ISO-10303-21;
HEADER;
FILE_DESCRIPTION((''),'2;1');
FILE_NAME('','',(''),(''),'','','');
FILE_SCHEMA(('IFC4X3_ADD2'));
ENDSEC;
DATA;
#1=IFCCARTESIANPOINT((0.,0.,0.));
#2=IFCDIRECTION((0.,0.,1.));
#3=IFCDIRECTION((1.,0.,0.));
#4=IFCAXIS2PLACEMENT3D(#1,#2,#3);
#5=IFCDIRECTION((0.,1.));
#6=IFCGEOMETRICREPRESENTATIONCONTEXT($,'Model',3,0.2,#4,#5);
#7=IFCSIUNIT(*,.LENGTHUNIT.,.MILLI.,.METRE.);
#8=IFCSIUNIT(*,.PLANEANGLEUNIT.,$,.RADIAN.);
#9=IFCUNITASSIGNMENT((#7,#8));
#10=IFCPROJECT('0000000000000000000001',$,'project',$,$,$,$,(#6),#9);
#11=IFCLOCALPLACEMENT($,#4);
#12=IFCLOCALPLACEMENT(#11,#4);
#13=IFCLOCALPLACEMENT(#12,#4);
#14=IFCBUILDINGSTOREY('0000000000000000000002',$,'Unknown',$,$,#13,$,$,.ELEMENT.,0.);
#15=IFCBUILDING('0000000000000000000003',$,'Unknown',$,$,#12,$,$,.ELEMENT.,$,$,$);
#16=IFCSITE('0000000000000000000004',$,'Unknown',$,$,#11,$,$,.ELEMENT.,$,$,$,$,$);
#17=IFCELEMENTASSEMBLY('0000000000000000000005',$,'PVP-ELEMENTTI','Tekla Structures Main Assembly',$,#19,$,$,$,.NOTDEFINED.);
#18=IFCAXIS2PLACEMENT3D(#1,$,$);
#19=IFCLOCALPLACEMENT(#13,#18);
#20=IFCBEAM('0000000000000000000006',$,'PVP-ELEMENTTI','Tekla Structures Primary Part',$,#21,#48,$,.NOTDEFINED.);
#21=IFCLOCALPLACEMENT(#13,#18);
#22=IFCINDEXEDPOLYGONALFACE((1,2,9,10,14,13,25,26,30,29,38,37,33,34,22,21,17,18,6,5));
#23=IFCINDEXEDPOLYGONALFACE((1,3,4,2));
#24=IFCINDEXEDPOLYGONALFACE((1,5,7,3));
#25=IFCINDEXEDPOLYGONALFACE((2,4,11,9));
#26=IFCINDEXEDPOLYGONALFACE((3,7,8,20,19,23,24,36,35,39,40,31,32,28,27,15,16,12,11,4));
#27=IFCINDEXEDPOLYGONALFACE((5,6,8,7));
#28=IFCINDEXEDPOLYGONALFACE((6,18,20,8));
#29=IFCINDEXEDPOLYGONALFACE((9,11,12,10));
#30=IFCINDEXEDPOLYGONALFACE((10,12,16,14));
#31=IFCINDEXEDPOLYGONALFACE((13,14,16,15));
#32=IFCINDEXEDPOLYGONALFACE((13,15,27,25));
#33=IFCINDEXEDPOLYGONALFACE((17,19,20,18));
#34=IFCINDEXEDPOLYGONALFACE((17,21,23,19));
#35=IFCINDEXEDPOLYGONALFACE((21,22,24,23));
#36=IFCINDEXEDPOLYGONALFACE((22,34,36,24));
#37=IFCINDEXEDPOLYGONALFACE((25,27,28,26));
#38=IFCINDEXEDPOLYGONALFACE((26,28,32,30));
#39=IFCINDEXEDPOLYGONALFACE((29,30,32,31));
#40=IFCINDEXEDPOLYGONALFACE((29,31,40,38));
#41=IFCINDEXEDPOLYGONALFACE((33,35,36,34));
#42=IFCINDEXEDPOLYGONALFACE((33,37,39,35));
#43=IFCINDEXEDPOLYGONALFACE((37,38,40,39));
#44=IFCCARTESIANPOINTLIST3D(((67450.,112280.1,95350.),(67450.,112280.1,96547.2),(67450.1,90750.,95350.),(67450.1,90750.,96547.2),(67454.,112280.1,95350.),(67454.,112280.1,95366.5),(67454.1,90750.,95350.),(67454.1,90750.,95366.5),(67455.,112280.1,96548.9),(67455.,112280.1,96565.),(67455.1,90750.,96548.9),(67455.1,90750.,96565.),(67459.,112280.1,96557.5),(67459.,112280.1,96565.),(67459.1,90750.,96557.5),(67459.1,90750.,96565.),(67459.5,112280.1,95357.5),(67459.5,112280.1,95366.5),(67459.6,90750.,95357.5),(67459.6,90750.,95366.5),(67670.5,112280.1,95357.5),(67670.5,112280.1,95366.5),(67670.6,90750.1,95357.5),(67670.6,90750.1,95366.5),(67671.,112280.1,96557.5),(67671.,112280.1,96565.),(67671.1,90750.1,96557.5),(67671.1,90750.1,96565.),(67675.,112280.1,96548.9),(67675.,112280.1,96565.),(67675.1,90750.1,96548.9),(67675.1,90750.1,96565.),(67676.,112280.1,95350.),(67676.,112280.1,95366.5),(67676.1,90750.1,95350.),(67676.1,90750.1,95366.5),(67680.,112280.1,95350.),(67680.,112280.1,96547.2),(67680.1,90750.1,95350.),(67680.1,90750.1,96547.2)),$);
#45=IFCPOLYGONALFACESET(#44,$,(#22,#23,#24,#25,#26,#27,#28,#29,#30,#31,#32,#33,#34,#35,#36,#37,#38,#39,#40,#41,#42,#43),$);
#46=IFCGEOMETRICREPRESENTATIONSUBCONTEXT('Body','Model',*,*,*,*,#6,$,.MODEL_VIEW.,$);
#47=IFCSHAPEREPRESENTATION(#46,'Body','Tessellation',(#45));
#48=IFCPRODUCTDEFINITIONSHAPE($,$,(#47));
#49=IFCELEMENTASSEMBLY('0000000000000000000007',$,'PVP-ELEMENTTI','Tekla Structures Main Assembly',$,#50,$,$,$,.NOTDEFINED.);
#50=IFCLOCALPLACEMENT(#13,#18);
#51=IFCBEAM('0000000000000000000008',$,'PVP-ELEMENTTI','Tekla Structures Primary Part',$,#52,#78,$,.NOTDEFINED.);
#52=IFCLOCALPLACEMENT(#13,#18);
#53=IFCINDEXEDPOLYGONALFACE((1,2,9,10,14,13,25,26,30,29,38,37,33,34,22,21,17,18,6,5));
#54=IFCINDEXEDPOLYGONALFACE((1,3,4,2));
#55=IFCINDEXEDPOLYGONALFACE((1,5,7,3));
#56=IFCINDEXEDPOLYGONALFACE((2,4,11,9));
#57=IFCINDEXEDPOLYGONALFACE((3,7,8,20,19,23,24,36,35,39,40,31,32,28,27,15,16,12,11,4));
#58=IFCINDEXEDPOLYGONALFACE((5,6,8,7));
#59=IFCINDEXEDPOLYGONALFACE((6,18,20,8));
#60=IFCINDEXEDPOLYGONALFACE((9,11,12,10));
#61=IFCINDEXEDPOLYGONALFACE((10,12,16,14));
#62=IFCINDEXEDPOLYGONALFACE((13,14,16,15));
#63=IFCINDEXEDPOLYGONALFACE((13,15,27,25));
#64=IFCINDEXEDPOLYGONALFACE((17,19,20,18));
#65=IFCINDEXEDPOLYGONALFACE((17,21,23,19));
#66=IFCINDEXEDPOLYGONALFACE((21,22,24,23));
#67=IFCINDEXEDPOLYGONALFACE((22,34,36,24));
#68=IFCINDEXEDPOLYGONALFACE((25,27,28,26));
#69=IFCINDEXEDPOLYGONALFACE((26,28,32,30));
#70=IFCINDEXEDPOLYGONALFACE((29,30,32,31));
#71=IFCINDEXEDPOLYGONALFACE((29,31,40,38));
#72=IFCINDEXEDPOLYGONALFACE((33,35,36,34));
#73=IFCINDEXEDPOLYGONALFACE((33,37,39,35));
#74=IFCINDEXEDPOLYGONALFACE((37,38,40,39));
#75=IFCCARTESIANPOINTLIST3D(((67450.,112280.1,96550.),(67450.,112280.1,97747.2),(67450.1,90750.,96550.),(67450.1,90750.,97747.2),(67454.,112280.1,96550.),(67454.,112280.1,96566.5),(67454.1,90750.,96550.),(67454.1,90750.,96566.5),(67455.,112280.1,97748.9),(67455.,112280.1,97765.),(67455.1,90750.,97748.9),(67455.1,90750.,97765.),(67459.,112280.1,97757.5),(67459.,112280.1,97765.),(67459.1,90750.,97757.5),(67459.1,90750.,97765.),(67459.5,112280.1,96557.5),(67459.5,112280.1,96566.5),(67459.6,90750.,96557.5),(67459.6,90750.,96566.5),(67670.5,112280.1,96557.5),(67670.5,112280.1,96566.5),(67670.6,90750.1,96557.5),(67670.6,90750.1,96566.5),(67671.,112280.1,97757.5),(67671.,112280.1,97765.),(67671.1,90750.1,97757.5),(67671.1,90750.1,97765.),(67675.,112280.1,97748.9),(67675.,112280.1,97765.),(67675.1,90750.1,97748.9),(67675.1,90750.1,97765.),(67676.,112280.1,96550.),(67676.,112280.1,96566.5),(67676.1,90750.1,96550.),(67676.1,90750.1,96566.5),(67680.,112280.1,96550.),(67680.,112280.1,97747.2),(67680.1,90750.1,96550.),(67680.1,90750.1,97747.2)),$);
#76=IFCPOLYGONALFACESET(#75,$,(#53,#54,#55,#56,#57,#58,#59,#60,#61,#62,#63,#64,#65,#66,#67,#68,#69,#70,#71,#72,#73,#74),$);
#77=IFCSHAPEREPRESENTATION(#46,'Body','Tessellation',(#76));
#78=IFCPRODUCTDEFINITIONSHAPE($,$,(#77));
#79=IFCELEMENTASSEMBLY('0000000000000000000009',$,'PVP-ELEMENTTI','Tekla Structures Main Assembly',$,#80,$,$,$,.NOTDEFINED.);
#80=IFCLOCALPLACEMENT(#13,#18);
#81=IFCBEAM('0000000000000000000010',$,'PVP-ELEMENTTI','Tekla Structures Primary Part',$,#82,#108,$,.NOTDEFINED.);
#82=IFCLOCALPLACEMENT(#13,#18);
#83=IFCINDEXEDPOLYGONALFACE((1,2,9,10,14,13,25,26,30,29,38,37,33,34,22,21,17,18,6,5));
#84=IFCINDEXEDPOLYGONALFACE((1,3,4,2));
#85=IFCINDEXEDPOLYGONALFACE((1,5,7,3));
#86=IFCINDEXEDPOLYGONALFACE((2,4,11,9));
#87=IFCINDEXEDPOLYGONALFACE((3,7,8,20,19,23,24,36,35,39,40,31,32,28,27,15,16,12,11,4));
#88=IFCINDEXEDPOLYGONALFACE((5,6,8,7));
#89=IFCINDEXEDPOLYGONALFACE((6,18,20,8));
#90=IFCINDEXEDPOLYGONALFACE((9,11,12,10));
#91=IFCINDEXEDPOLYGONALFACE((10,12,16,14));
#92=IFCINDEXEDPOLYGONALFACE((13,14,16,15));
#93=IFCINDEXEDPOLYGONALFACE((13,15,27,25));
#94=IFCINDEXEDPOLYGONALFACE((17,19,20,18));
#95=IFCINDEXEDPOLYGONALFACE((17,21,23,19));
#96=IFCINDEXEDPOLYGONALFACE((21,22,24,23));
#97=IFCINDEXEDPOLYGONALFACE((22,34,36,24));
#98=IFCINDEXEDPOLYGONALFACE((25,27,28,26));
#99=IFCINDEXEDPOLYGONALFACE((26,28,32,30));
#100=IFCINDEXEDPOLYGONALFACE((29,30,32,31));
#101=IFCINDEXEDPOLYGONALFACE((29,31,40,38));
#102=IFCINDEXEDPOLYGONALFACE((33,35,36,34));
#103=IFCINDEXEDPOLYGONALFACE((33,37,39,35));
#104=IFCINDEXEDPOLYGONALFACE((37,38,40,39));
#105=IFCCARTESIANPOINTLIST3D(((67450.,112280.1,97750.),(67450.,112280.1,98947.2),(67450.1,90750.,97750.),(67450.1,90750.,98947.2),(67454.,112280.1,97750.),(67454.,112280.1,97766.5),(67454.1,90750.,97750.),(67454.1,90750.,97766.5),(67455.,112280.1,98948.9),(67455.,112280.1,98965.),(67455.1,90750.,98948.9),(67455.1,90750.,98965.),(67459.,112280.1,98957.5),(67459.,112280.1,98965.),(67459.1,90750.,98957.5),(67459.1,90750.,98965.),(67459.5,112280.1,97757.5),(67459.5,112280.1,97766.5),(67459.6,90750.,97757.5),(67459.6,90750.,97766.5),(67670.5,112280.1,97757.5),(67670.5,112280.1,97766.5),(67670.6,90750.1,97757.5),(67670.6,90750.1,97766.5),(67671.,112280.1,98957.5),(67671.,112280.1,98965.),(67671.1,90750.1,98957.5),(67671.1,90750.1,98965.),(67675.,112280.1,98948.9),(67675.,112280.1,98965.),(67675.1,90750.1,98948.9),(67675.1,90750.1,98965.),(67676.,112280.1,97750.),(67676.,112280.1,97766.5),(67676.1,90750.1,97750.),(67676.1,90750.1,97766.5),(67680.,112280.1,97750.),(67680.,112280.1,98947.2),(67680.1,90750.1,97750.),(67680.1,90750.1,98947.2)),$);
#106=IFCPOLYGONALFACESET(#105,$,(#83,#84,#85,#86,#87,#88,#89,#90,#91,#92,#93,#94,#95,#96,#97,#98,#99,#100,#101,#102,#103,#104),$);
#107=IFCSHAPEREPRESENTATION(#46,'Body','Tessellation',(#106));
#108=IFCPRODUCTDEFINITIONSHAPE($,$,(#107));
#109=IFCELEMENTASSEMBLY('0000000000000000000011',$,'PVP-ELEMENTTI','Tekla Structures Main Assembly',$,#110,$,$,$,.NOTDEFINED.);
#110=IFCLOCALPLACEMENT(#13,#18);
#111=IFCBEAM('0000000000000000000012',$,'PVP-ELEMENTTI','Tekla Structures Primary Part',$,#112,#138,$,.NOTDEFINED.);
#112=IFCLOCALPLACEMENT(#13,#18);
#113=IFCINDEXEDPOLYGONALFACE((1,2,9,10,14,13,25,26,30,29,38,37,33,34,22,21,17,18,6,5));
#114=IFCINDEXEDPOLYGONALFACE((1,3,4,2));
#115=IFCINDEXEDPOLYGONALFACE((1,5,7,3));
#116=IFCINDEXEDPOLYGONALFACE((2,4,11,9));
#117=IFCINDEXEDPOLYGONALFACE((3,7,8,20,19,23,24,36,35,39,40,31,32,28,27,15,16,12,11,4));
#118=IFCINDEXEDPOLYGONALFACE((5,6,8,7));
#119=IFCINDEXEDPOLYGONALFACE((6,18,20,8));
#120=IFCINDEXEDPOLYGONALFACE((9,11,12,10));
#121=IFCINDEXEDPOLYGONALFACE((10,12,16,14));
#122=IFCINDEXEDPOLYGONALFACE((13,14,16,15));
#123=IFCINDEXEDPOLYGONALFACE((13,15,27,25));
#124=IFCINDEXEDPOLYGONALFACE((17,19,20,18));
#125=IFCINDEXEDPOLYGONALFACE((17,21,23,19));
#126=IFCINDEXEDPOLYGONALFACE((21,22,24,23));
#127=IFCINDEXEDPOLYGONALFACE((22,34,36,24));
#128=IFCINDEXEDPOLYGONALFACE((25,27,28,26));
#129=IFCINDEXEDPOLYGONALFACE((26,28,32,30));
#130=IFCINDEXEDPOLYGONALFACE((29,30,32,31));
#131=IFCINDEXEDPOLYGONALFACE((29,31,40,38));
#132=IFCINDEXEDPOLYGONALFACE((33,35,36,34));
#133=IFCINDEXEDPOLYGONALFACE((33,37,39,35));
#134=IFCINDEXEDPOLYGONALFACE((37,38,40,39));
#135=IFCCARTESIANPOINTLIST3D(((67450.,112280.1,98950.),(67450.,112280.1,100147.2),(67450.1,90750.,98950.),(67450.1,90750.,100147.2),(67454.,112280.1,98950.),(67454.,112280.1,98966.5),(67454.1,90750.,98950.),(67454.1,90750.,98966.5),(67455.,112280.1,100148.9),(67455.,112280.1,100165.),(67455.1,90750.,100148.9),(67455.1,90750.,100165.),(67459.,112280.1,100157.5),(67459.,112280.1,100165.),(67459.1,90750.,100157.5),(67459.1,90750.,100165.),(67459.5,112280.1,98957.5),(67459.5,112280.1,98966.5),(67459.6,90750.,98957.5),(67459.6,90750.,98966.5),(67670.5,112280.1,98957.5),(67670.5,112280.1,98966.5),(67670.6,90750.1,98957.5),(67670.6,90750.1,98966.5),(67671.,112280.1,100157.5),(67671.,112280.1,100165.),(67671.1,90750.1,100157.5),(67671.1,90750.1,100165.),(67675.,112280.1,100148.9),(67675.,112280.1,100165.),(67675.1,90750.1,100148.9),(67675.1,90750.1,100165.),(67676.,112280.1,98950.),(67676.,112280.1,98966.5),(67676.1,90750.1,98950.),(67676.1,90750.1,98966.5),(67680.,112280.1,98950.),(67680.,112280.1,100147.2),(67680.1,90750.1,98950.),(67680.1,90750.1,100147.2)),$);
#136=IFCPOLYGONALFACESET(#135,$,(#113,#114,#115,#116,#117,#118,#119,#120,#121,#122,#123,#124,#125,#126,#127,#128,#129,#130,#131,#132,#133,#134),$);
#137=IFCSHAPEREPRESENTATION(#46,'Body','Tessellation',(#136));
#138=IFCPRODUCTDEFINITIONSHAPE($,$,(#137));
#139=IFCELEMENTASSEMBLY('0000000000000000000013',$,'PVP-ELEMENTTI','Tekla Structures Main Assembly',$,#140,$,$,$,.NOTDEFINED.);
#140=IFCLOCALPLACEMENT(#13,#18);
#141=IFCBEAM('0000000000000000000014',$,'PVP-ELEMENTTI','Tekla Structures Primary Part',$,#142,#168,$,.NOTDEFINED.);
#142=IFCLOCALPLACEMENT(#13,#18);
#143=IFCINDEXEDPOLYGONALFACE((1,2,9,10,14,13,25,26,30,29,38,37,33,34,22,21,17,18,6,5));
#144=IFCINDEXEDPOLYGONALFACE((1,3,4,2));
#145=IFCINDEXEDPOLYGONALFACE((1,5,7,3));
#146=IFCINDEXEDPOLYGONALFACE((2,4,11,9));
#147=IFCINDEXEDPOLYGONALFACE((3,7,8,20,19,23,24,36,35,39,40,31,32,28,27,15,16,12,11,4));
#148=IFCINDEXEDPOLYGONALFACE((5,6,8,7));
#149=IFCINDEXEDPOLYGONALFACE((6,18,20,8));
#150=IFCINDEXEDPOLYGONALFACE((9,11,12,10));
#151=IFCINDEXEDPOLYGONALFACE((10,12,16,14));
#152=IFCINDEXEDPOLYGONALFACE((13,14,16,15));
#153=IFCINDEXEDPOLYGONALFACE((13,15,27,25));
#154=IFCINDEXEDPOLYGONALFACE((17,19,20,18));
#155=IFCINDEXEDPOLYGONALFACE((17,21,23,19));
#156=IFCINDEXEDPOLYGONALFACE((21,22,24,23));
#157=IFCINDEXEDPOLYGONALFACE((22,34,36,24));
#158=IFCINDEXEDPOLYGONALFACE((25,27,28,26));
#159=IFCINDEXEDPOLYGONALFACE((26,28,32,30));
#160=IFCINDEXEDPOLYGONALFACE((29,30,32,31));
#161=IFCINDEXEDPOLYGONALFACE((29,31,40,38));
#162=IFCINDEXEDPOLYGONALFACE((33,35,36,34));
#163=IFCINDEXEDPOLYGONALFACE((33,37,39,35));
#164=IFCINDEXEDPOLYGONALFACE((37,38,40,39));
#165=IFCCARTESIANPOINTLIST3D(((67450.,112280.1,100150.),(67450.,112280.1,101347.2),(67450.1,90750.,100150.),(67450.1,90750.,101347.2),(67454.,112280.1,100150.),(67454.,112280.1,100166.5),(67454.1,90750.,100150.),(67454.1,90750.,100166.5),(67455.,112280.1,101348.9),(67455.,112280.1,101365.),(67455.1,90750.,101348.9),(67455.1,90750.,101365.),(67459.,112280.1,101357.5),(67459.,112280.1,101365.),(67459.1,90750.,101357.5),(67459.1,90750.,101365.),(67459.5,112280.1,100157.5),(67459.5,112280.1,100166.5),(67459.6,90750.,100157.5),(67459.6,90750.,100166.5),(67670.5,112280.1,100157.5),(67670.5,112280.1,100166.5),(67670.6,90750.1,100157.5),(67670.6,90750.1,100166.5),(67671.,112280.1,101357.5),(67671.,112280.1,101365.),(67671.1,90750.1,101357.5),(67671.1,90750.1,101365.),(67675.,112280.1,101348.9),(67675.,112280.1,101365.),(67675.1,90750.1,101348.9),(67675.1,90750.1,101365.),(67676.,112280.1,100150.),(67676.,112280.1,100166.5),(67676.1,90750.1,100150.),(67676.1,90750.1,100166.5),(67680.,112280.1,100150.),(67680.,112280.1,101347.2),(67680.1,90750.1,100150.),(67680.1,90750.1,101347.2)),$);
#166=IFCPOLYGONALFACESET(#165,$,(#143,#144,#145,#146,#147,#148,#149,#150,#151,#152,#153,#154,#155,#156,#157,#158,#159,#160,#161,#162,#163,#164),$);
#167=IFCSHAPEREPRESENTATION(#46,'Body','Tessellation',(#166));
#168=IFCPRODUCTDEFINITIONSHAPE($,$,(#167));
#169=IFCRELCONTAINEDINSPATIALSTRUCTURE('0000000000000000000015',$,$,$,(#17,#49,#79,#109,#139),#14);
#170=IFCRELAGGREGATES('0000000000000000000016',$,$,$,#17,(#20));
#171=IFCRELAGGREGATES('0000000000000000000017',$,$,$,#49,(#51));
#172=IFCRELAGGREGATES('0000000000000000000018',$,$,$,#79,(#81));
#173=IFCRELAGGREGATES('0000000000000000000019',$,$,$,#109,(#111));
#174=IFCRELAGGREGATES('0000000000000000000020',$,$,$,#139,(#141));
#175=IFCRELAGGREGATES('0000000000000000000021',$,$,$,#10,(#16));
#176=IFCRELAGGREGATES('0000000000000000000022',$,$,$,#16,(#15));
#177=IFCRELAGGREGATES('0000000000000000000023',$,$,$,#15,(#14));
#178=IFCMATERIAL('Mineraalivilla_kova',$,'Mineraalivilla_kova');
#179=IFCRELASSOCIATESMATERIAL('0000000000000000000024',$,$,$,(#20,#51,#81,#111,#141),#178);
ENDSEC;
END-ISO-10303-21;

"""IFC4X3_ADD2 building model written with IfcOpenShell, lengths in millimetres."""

from ifc_helpers import new_model, si_unit, direction, frame, origin_with_axes, place, context, subcontext, project, spatial, line, indexed_curve, outline, extrude, material, element, aggregate, save


model = new_model("IFC4X3_ADD2")

# Units and contexts
model_context = context("Model", 3, precision=0.2, world=origin_with_axes(), true_north=direction((0.0, 1.0)))
body_context = subcontext(model_context, "Body", "Model", "MODEL_VIEW")
ifc_project = project(units=[si_unit("LENGTHUNIT", "METRE", prefix="MILLI"), si_unit("PLANEANGLEUNIT", "RADIAN")], contexts=[model_context])

# Site, building, storey
site_placement = place(None, origin_with_axes())
site = spatial("IfcSite", under=ifc_project, at=site_placement, Name="Unknown", CompositionType="ELEMENT")
building_placement = place(site_placement, origin_with_axes())
building = spatial("IfcBuilding", under=site, at=building_placement, Name="Unknown", CompositionType="ELEMENT")
storey_placement = place(building_placement, origin_with_axes())
storey = spatial("IfcBuildingStorey", under=building, at=storey_placement, Name="Unknown", CompositionType="ELEMENT", Elevation=0.0)

# Element assemblies, beams
ifc_material_1 = material(Name="Mineraalivilla_kova", Category="Mineraalivilla_kova")
assembly_1_placement = place(storey_placement, frame((67565.0, 112280.1, 95950.0), z_axis=(-1.0, -0.000005, 0.0), x_axis=(0.000005, -1.0, 0.0)))
assembly_1 = element("IfcElementAssembly", 1, at=assembly_1_placement, inside=storey, Name="PVP-ELEMENTTI", Description="Tekla Structures Main Assembly", PredefinedType="NOTDEFINED")
beam_1_placement = place(assembly_1_placement, origin_with_axes())
beam_1 = element("IfcBeam", 2, at=beam_1_placement, material=ifc_material_1, Name="PVP-ELEMENTTI", Description="Tekla Structures Primary Part", PredefinedType="NOTDEFINED", context=body_context, shape_type="SolidModel", body=[
    extrude(outline(indexed_curve([(110.0, 615.0), (106.0, 615.0), (106.0, 607.5), (-106.0, 607.5), (-106.0, 615.0), (-110.0, 615.0), (-110.0, 598.9), (-115.0, 597.2), (-115.0, -600.0), (-111.0, -600.0), (-111.0, -583.5), (-105.5, -583.5), (-105.5, -592.5), (105.5, -592.5), (105.5, -583.5), (111.0, -583.5), (111.0, -600.0), (115.0, -600.0), (115.0, 597.2), (110.0, 598.9)], segments=[line(1, 2, 3, 4, 5, 6, 7, 8, 9, 10, 11, 12, 13, 14, 15, 16, 17, 18, 19, 20, 1)])), frame((0.0, 0.0, 0.0), z_axis=(-1.0, 0.0, 0.0), x_axis=(0.0, 0.0, 1.0)), (0.0, 0.0, -1.0), 21530.0),
])
aggregate(assembly_1, [beam_1])
assembly_2_placement = place(storey_placement, frame((67565.0, 112280.1, 97150.0), z_axis=(-1.0, -0.000005, 0.0), x_axis=(0.000005, -1.0, 0.0)))
assembly_2 = element("IfcElementAssembly", 3, at=assembly_2_placement, inside=storey, Name="PVP-ELEMENTTI", Description="Tekla Structures Main Assembly", PredefinedType="NOTDEFINED")
beam_2_placement = place(assembly_2_placement, origin_with_axes())
beam_2 = element("IfcBeam", 4, at=beam_2_placement, material=ifc_material_1, Name="PVP-ELEMENTTI", Description="Tekla Structures Primary Part", PredefinedType="NOTDEFINED", context=body_context, shape_type="SolidModel", body=[
    extrude(outline(indexed_curve([(110.0, 615.0), (106.0, 615.0), (106.0, 607.5), (-106.0, 607.5), (-106.0, 615.0), (-110.0, 615.0), (-110.0, 598.9), (-115.0, 597.2), (-115.0, -600.0), (-111.0, -600.0), (-111.0, -583.5), (-105.5, -583.5), (-105.5, -592.5), (105.5, -592.5), (105.5, -583.5), (111.0, -583.5), (111.0, -600.0), (115.0, -600.0), (115.0, 597.2), (110.0, 598.9)], segments=[line(1, 2, 3, 4, 5, 6, 7, 8, 9, 10, 11, 12, 13, 14, 15, 16, 17, 18, 19, 20, 1)])), frame((0.0, 0.0, 0.0), z_axis=(-1.0, 0.0, 0.0), x_axis=(0.0, 0.0, 1.0)), (0.0, 0.0, -1.0), 21530.0),
])
aggregate(assembly_2, [beam_2])
assembly_3_placement = place(storey_placement, frame((67565.0, 112280.1, 98350.0), z_axis=(-1.0, -0.000005, 0.0), x_axis=(0.000005, -1.0, 0.0)))
assembly_3 = element("IfcElementAssembly", 5, at=assembly_3_placement, inside=storey, Name="PVP-ELEMENTTI", Description="Tekla Structures Main Assembly", PredefinedType="NOTDEFINED")
beam_3_placement = place(assembly_3_placement, origin_with_axes())
beam_3 = element("IfcBeam", 6, at=beam_3_placement, material=ifc_material_1, Name="PVP-ELEMENTTI", Description="Tekla Structures Primary Part", PredefinedType="NOTDEFINED", context=body_context, shape_type="SolidModel", body=[
    extrude(outline(indexed_curve([(110.0, 615.0), (106.0, 615.0), (106.0, 607.5), (-106.0, 607.5), (-106.0, 615.0), (-110.0, 615.0), (-110.0, 598.9), (-115.0, 597.2), (-115.0, -600.0), (-111.0, -600.0), (-111.0, -583.5), (-105.5, -583.5), (-105.5, -592.5), (105.5, -592.5), (105.5, -583.5), (111.0, -583.5), (111.0, -600.0), (115.0, -600.0), (115.0, 597.2), (110.0, 598.9)], segments=[line(1, 2, 3, 4, 5, 6, 7, 8, 9, 10, 11, 12, 13, 14, 15, 16, 17, 18, 19, 20, 1)])), frame((0.0, 0.0, 0.0), z_axis=(-1.0, 0.0, 0.0), x_axis=(0.0, 0.0, 1.0)), (0.0, 0.0, -1.0), 21530.0),
])
aggregate(assembly_3, [beam_3])
assembly_4_placement = place(storey_placement, frame((67565.0, 112280.1, 99550.0), z_axis=(-1.0, -0.000005, 0.0), x_axis=(0.000005, -1.0, 0.0)))
assembly_4 = element("IfcElementAssembly", 7, at=assembly_4_placement, inside=storey, Name="PVP-ELEMENTTI", Description="Tekla Structures Main Assembly", PredefinedType="NOTDEFINED")
beam_4_placement = place(assembly_4_placement, origin_with_axes())
beam_4 = element("IfcBeam", 8, at=beam_4_placement, material=ifc_material_1, Name="PVP-ELEMENTTI", Description="Tekla Structures Primary Part", PredefinedType="NOTDEFINED", context=body_context, shape_type="SolidModel", body=[
    extrude(outline(indexed_curve([(110.0, 615.0), (106.0, 615.0), (106.0, 607.5), (-106.0, 607.5), (-106.0, 615.0), (-110.0, 615.0), (-110.0, 598.9), (-115.0, 597.2), (-115.0, -600.0), (-111.0, -600.0), (-111.0, -583.5), (-105.5, -583.5), (-105.5, -592.5), (105.5, -592.5), (105.5, -583.5), (111.0, -583.5), (111.0, -600.0), (115.0, -600.0), (115.0, 597.2), (110.0, 598.9)], segments=[line(1, 2, 3, 4, 5, 6, 7, 8, 9, 10, 11, 12, 13, 14, 15, 16, 17, 18, 19, 20, 1)])), frame((0.0, 0.0, 0.0), z_axis=(-1.0, 0.0, 0.0), x_axis=(0.0, 0.0, 1.0)), (0.0, 0.0, -1.0), 21530.0),
])
aggregate(assembly_4, [beam_4])
assembly_5_placement = place(storey_placement, frame((67565.0, 112280.1, 100750.0), z_axis=(-1.0, -0.000005, 0.0), x_axis=(0.000005, -1.0, 0.0)))
assembly_5 = element("IfcElementAssembly", 9, at=assembly_5_placement, inside=storey, Name="PVP-ELEMENTTI", Description="Tekla Structures Main Assembly", PredefinedType="NOTDEFINED")
beam_5_placement = place(assembly_5_placement, origin_with_axes())
beam_5 = element("IfcBeam", 10, at=beam_5_placement, material=ifc_material_1, Name="PVP-ELEMENTTI", Description="Tekla Structures Primary Part", PredefinedType="NOTDEFINED", context=body_context, shape_type="SolidModel", body=[
    extrude(outline(indexed_curve([(110.0, 615.0), (106.0, 615.0), (106.0, 607.5), (-106.0, 607.5), (-106.0, 615.0), (-110.0, 615.0), (-110.0, 598.9), (-115.0, 597.2), (-115.0, -600.0), (-111.0, -600.0), (-111.0, -583.5), (-105.5, -583.5), (-105.5, -592.5), (105.5, -592.5), (105.5, -583.5), (111.0, -583.5), (111.0, -600.0), (115.0, -600.0), (115.0, 597.2), (110.0, 598.9)], segments=[line(1, 2, 3, 4, 5, 6, 7, 8, 9, 10, 11, 12, 13, 14, 15, 16, 17, 18, 19, 20, 1)])), frame((0.0, 0.0, 0.0), z_axis=(-1.0, 0.0, 0.0), x_axis=(0.0, 0.0, 1.0)), (0.0, 0.0, -1.0), 21530.0),
])
aggregate(assembly_5, [beam_5])

save(model, "model.ifc")
